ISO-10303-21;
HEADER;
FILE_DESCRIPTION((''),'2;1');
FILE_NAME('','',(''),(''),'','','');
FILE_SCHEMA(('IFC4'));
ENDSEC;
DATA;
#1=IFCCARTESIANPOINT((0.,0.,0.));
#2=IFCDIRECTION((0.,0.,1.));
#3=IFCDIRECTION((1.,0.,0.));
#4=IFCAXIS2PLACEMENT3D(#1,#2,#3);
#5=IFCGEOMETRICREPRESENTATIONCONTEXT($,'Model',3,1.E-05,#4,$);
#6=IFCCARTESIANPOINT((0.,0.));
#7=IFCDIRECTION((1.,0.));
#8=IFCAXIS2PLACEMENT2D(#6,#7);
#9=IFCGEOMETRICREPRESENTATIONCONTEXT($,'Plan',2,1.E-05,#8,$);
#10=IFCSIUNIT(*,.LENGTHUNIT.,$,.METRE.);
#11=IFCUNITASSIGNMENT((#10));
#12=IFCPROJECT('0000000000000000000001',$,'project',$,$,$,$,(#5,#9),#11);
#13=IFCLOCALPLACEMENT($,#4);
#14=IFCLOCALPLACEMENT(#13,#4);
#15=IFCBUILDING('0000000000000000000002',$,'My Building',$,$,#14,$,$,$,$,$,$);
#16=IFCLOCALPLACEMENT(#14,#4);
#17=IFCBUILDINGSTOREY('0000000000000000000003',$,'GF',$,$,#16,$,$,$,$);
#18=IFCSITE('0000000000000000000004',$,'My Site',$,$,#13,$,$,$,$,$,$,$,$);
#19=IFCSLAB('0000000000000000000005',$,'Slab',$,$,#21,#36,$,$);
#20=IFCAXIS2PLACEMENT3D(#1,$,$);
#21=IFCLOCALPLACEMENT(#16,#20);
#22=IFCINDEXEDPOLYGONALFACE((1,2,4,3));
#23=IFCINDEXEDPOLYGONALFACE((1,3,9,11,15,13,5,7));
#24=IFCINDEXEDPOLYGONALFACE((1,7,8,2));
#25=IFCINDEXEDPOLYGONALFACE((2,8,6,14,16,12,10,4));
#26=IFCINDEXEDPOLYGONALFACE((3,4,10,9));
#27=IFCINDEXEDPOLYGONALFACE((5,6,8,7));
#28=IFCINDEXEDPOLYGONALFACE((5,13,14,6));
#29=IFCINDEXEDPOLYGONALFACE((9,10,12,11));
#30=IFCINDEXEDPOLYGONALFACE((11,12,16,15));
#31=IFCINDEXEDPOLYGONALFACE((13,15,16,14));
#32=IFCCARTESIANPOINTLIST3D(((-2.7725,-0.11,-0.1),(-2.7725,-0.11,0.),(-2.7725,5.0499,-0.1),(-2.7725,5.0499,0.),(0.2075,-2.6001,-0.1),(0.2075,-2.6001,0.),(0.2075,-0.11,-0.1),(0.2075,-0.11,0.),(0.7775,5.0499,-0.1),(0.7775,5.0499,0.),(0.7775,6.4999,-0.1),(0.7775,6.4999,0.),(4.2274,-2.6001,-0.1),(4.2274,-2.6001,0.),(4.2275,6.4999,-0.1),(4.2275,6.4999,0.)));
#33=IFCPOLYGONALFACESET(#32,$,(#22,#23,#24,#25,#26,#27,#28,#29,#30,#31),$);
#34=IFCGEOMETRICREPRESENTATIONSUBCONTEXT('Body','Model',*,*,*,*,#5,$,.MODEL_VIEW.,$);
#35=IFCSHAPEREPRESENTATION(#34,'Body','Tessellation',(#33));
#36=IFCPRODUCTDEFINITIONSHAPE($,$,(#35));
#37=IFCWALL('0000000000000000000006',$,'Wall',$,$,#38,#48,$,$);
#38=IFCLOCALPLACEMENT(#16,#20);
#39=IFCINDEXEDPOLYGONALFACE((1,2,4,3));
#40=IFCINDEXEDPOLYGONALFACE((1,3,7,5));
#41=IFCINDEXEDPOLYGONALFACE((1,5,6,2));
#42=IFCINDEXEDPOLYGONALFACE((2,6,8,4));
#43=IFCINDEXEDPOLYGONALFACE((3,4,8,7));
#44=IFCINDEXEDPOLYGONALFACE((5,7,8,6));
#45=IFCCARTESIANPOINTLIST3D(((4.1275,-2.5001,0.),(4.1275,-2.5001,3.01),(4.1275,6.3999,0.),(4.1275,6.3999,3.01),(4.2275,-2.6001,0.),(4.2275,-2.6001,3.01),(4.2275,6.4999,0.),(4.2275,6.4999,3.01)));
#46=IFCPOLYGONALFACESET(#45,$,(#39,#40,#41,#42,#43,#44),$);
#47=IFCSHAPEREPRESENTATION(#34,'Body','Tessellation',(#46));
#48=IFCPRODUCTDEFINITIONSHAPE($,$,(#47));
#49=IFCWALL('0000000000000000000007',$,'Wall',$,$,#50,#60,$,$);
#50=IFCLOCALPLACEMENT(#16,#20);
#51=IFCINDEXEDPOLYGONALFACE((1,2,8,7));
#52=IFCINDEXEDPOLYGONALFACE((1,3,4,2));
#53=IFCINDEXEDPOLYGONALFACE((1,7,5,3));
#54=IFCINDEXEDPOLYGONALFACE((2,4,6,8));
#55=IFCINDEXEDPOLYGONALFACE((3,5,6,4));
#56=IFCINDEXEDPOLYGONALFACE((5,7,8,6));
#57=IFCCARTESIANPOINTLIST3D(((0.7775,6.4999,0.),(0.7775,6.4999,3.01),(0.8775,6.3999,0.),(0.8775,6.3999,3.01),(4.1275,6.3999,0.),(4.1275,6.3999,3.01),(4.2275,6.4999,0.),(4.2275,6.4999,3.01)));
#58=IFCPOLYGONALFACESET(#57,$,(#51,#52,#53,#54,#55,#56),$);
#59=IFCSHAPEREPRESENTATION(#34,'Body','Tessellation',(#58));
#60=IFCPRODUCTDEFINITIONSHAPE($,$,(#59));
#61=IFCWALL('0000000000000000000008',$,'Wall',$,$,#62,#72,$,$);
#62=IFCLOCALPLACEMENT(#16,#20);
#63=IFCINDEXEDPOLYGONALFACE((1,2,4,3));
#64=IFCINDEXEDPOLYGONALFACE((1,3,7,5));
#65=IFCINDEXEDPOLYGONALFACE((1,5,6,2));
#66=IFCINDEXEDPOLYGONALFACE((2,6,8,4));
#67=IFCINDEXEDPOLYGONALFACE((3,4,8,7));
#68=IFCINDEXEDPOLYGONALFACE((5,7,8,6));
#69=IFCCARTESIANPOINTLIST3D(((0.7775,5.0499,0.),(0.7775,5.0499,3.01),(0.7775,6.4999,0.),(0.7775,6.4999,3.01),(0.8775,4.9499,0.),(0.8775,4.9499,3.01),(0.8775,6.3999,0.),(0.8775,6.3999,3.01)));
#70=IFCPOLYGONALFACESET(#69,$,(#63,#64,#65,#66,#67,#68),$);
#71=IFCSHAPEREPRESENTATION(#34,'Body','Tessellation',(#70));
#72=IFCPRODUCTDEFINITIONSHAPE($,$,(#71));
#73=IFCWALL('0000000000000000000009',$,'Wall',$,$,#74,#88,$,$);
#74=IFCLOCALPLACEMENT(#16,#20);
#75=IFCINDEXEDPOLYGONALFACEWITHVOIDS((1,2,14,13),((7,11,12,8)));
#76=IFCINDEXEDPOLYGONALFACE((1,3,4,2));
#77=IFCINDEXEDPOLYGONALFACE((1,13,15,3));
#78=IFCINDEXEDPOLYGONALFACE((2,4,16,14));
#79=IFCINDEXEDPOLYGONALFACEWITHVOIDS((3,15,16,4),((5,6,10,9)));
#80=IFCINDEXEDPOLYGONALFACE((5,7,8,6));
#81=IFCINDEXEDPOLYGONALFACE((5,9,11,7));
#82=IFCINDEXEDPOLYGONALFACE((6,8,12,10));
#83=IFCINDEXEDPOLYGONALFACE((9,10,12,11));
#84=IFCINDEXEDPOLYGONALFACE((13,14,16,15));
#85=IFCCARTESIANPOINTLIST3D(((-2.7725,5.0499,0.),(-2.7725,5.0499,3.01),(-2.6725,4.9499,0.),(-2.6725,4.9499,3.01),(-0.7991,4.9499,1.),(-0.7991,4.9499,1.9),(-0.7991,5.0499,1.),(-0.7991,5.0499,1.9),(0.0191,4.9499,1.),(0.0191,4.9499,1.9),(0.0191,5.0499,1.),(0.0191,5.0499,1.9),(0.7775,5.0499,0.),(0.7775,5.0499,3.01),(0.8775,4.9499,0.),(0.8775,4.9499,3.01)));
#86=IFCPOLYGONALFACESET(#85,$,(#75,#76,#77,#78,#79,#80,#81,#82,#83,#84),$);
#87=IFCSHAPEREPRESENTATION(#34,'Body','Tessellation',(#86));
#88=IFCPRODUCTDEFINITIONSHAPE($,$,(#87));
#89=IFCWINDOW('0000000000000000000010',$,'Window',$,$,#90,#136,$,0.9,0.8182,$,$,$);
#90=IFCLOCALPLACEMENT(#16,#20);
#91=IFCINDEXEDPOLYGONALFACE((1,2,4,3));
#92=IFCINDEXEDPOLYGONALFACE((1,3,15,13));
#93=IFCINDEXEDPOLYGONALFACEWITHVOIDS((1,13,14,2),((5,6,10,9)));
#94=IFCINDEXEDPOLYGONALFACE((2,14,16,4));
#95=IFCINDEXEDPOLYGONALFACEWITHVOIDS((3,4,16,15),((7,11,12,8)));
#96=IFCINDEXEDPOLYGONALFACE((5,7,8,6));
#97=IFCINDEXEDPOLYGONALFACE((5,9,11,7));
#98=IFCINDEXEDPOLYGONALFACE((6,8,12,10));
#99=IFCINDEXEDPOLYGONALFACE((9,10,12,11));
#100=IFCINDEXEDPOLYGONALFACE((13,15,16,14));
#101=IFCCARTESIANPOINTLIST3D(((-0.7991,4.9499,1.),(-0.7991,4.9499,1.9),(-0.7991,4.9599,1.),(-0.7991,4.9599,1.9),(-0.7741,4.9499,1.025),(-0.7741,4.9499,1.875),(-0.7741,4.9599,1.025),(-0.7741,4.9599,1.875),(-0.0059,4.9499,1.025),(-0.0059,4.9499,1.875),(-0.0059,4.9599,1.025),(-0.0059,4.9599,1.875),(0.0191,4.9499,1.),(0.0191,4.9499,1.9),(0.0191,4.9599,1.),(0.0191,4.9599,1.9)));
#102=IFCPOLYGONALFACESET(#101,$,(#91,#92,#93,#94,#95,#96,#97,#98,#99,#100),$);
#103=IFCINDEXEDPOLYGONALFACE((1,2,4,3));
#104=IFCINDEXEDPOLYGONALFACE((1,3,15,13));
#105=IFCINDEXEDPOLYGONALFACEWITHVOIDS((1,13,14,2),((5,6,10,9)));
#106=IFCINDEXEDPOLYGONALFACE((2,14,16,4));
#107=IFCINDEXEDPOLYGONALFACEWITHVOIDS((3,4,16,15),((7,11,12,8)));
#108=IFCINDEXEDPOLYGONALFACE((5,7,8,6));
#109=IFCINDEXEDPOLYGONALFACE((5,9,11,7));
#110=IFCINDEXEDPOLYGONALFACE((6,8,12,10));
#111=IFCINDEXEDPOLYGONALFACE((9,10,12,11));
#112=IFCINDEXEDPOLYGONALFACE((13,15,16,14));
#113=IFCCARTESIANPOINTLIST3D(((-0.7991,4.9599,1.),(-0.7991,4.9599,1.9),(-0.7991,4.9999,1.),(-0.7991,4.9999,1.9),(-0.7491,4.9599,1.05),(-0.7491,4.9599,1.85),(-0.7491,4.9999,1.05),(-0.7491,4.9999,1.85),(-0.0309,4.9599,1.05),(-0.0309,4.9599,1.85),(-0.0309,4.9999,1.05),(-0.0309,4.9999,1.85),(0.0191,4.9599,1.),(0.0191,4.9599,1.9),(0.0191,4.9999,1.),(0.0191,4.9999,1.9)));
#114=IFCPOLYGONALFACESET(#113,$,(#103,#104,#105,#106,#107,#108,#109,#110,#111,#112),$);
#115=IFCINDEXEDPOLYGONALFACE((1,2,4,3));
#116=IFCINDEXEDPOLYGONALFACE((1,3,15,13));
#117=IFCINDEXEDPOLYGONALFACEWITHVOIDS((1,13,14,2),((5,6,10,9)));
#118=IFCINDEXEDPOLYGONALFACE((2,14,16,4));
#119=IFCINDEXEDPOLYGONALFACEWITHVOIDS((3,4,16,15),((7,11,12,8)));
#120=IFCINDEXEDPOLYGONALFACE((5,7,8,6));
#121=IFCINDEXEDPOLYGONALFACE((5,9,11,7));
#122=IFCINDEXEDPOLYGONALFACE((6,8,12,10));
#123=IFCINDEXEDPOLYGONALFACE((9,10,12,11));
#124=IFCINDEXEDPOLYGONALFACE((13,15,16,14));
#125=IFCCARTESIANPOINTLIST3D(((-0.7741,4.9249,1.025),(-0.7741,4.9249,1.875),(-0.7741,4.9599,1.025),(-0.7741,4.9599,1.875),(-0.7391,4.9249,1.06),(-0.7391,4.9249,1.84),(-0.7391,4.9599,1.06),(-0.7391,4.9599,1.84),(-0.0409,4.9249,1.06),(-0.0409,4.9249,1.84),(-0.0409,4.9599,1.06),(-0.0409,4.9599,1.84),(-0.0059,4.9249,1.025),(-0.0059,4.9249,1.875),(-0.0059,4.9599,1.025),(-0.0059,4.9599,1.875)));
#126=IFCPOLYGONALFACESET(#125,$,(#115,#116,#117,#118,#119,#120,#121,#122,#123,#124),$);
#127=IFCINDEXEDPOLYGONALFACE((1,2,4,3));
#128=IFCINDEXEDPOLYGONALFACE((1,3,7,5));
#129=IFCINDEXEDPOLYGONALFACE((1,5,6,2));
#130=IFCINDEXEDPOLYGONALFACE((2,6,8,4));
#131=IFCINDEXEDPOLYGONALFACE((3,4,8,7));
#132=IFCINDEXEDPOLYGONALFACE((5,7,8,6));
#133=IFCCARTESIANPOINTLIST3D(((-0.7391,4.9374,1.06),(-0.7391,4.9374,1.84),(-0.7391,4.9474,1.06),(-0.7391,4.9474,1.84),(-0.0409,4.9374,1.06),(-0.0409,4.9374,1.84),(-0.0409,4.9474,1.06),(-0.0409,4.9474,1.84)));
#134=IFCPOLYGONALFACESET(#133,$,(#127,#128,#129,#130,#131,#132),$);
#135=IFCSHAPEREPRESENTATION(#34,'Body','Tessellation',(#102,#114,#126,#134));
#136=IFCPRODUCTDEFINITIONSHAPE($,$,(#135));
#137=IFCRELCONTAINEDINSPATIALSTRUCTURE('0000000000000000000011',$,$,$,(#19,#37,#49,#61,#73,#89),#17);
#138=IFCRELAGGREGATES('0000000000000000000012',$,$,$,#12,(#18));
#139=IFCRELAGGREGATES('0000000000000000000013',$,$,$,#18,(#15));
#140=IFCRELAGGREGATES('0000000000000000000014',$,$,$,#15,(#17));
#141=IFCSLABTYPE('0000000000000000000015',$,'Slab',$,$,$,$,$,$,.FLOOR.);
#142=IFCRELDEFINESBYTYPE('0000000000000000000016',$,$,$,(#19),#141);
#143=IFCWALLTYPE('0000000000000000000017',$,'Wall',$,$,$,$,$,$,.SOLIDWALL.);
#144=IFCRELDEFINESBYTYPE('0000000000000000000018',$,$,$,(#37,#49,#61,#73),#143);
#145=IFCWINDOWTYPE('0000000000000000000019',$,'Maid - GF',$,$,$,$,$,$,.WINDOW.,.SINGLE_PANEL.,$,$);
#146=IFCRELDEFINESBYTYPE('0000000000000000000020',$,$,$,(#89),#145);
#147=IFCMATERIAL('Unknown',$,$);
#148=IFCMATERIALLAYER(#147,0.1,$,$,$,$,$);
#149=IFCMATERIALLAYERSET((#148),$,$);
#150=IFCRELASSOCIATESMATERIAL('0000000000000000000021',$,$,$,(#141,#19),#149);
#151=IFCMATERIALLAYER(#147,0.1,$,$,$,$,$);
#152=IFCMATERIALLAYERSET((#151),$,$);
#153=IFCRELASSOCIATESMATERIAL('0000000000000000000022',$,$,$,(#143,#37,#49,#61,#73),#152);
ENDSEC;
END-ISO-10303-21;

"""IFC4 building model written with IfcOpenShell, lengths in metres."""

from ifc_helpers import new_model, entity, si_unit, frame, origin_with_axes, origin_2d_with_axis, place, context, subcontext, project, spatial, line, indexed_curve, outline, extrude, shape, source, transform, mapped, material, layer, layer_set, layer_usage, type_object, type_shapes, element, fill, save


model = new_model("IFC4")

# Units and contexts
model_context = context("Model", 3, precision=1e-05, world=origin_with_axes())
plan_context = context("Plan", 2, precision=1e-05, world=origin_2d_with_axis())
body_context_1 = subcontext(model_context, "Body", "Model", "MODEL_VIEW")
body_context_2 = subcontext(plan_context, "Body", "Plan", "PLAN_VIEW")
ifc_project = project(units=[si_unit("LENGTHUNIT", "METRE")], contexts=[model_context, plan_context])

# Site, building, storey
site_placement = place(None, origin_with_axes())
site = spatial("IfcSite", under=ifc_project, at=site_placement, Name="My Site")
building_placement = place(site_placement, origin_with_axes())
building = spatial("IfcBuilding", under=site, at=building_placement, Name="My Building")
storey_placement = place(building_placement, origin_with_axes())
storey = spatial("IfcBuildingStorey", under=building, at=storey_placement, Name="GF")

# Slab
ifc_material = material(Name="Unknown")
ifc_layer_1 = layer(ifc_material, 0.1)
ifc_layer_set_1 = layer_set([ifc_layer_1])
ifc_layer_usage_1 = layer_usage(ifc_layer_set_1, "AXIS3", "POSITIVE", -0.1)
slab_type = type_object("IfcSlabType", Name="Slab", PredefinedType="FLOOR", material=ifc_layer_set_1)
slab_placement = place(storey_placement, frame((4.2275, 6.4999, 0.0), z_axis=(0.0, 0.0, 1.0), x_axis=(1.0, 0.0, 0.0)))
element("IfcSlab", 1, at=slab_placement, inside=storey, type_object=slab_type, material=ifc_layer_usage_1, Name="Slab", context=body_context_1, shape_type="SweptSolid", body=[
    extrude(outline(indexed_curve([(0.0, 0.0), (-3.45, 0.0), (-3.45, -1.45), (-7.0, -1.45), (-7.0, -6.61), (-4.02, -6.61), (-4.02, -9.1), (-0.0001, -9.1), (0.0, 0.0)])), frame((0.0, 0.0, -0.1), z_axis=(0.0, 0.0, 1.0), x_axis=(1.0, 0.0, 0.0)), (0.0, 0.0, 1.0), 0.1),
])

# Shared definitions
ifc_layer_2 = layer(ifc_material, 0.1)
ifc_layer_set_2 = layer_set([ifc_layer_2])
wall_type = type_object("IfcWallType", Name="Wall", PredefinedType="SOLIDWALL", material=ifc_layer_set_2)

# Walls
ifc_layer_usage_2 = layer_usage(ifc_layer_set_2, "AXIS2", "POSITIVE", 0.0)
wall_1_placement = place(storey_placement, frame((4.2275, -2.6001, 0.0), z_axis=(0.0, 0.0, 1.0), x_axis=(0.0, 1.0, 0.0)))
element("IfcWall", 2, at=wall_1_placement, inside=storey, type_object=wall_type, material=ifc_layer_usage_2, Name="Wall", context=body_context_1, shape_type="SweptSolid", body=[
    extrude(outline(indexed_curve([(0.0, 0.0), (0.1, 0.1), (9.0, 0.1), (9.1, 0.0)], segments=[line(1, 2, 3, 4, 1)])), origin_with_axes(), (0.0, 0.0, 1.0), 3.01),
])
ifc_layer_usage_3 = layer_usage(ifc_layer_set_2, "AXIS2", "POSITIVE", 0.0)
wall_2_placement = place(storey_placement, frame((4.2275, 6.4999, 0.0), z_axis=(0.0, 0.0, 1.0), x_axis=(-1.0, 0.0, 0.0)))
element("IfcWall", 3, at=wall_2_placement, inside=storey, type_object=wall_type, material=ifc_layer_usage_3, Name="Wall", context=body_context_1, shape_type="SweptSolid", body=[
    extrude(outline(indexed_curve([(0.0, 0.0), (0.1, 0.1), (3.35, 0.1), (3.45, 0.0)], segments=[line(1, 2, 3, 4, 1)])), origin_with_axes(), (0.0, 0.0, 1.0), 3.01),
])
ifc_layer_usage_4 = layer_usage(ifc_layer_set_2, "AXIS2", "POSITIVE", 0.0)
wall_3_placement = place(storey_placement, frame((0.7775, 6.4999, 0.0), z_axis=(0.0, 0.0, 1.0), x_axis=(0.0, -1.0, 0.0)))
element("IfcWall", 4, at=wall_3_placement, inside=storey, type_object=wall_type, material=ifc_layer_usage_4, Name="Wall", context=body_context_1, shape_type="SweptSolid", body=[
    extrude(outline(indexed_curve([(0.0, 0.0), (0.1, 0.1), (1.55, 0.1), (1.45, 0.0)], segments=[line(1, 2, 3, 4, 1)])), origin_with_axes(), (0.0, 0.0, 1.0), 3.01),
])

# Wall, opening, window
ifc_layer_usage_5 = layer_usage(ifc_layer_set_2, "AXIS2", "POSITIVE", 0.0)
wall_4_placement = place(storey_placement, frame((0.7775, 5.0499, 0.0), z_axis=(0.0, 0.0, 1.0), x_axis=(-1.0, 0.0, 0.0)))
wall_4 = element("IfcWall", 5, at=wall_4_placement, inside=storey, type_object=wall_type, material=ifc_layer_usage_5, Name="Wall", context=body_context_1, shape_type="SweptSolid", body=[
    extrude(outline(indexed_curve([(0.0, 0.0), (-0.1, 0.1), (3.45, 0.1), (3.55, 0.0)], segments=[line(1, 2, 3, 4, 1)])), origin_with_axes(), (0.0, 0.0, 1.0), 3.01),
])
shared_shape_1 = source(origin_with_axes(), body_context_1, "Body", "SweptSolid", [
    extrude(outline(indexed_curve([(0.0, 0.0), (0.8182, 0.0), (0.8182, 0.9), (0.0, 0.9)], segments=[line(1, 2, 3, 4, 1)])), frame((0.0, -0.6, 0.0), z_axis=(0.0, -1.0, 0.0), x_axis=(1.0, 0.0, 0.0)), (0.0, 0.0, -1.0), 1.2),
])
opening_1_placement = place(wall_4_placement, frame((0.7584, 0.0, 1.0), z_axis=(0.0, 0.0, 1.0), x_axis=(1.0, 0.0, 0.0)))
opening_1 = element("IfcOpeningElement", 6, at=opening_1_placement, cuts=wall_4, PredefinedType="OPENING", context=body_context_1, shape_type="MappedRepresentation", body=[
    mapped(shared_shape_1, transform((0.0, 0.0, 0.0), x_axis=(1.0, 0.0, 0.0), y_axis=(0.0, 1.0, 0.0), z_axis=(0.0, 0.0, 1.0), scale=1.0)),
])
window_type_1 = type_object("IfcWindowType", Name="Maid - GF", PartitioningType="SINGLE_PANEL", PredefinedType="WINDOW")
shared_shape_2 = source(origin_with_axes(), body_context_1, "Body", "SweptSolid", [
    extrude(outline(indexed_curve([(0.0, 0.0), (0.8182, 0.0), (0.8182, 0.9), (0.0, 0.9)], segments=[line(1, 2, 3, 4, 1)]), holes=[indexed_curve([(0.025, 0.025), (0.7932, 0.025), (0.7932, 0.875), (0.025, 0.875)], segments=[line(1, 2, 3, 4, 1)])]), frame((0.0, 0.09, 0.0), z_axis=(0.0, -1.0, 0.0), x_axis=(1.0, 0.0, 0.0)), (0.0, 0.0, -1.0), 0.01),
    extrude(outline(indexed_curve([(0.0, 0.0), (0.8182, 0.0), (0.8182, 0.9), (0.0, 0.9)], segments=[line(1, 2, 3, 4, 1)]), holes=[indexed_curve([(0.05, 0.05), (0.7682, 0.05), (0.7682, 0.85), (0.05, 0.85)], segments=[line(1, 2, 3, 4, 1)])]), frame((0.0, 0.05, 0.0), z_axis=(0.0, -1.0, 0.0), x_axis=(1.0, 0.0, 0.0)), (0.0, 0.0, -1.0), 0.04),
    extrude(outline(indexed_curve([(0.0, 0.0), (0.7682, 0.0), (0.7682, 0.85), (0.0, 0.85)], segments=[line(1, 2, 3, 4, 1)]), holes=[indexed_curve([(0.035, 0.035), (0.7332, 0.035), (0.7332, 0.815), (0.035, 0.815)], segments=[line(1, 2, 3, 4, 1)])]), frame((0.025, 0.09, 0.025), z_axis=(0.0, -1.0, 0.0), x_axis=(1.0, 0.0, 0.0)), (0.0, 0.0, -1.0), 0.035),
    extrude(outline(indexed_curve([(0.035, 0.035), (0.7332, 0.035), (0.7332, 0.815), (0.035, 0.815)], segments=[line(1, 2, 3, 4, 1)])), frame((0.025, 0.1025, 0.025), z_axis=(0.0, -1.0, 0.0), x_axis=(1.0, 0.0, 0.0)), (0.0, 0.0, -1.0), 0.01),
])
shared_shape_3 = source(origin_with_axes(), body_context_2, "Body", "Curve2D", [
    entity("IfcIndexedPolyCurve", entity("IfcCartesianPointList2D", [[0.05, 0.05], [0.7682, 0.05]])),
    entity("IfcIndexedPolyCurve", entity("IfcCartesianPointList2D", [[0.0, 0.1], [0.025, 0.1], [0.025, 0.09], [0.05, 0.09], [0.05, 0.05], [0.0, 0.05]]), [entity("IfcLineIndex", [1, 2, 3, 4, 5, 6, 1])]),
    entity("IfcIndexedPolyCurve", entity("IfcCartesianPointList2D", [[0.8182, 0.1], [0.7932, 0.1], [0.7932, 0.09], [0.7682, 0.09], [0.7682, 0.05], [0.8182, 0.05]]), [entity("IfcLineIndex", [1, 2, 3, 4, 5, 6, 1])]),
    entity("IfcIndexedPolyCurve", entity("IfcCartesianPointList2D", [[0.025, 0.09], [0.06, 0.09], [0.06, 0.125], [0.025, 0.125]]), [entity("IfcLineIndex", [1, 2, 3, 4, 1])]),
    entity("IfcIndexedPolyCurve", entity("IfcCartesianPointList2D", [[0.7932, 0.09], [0.7582, 0.09], [0.7582, 0.125], [0.7932, 0.125]]), [entity("IfcLineIndex", [1, 2, 3, 4, 1])]),
    entity("IfcIndexedPolyCurve", entity("IfcCartesianPointList2D", [[0.06, 0.09], [0.7582, 0.09]])),
    entity("IfcIndexedPolyCurve", entity("IfcCartesianPointList2D", [[0.06, 0.125], [0.7582, 0.125]])),
    entity("IfcIndexedPolyCurve", entity("IfcCartesianPointList2D", [[0.06, 0.1075], [0.7582, 0.1075]])),
])
type_shapes(window_type_1, [shared_shape_2, shared_shape_3])
window_1_placement = place(opening_1_placement, frame((0.0, 0.0, 0.0), z_axis=(0.0, 0.0, 1.0), x_axis=(1.0, 0.0, 0.0)))
window_1 = element("IfcWindow", 7, at=window_1_placement, inside=storey, type_object=window_type_1, Name="Window", OverallHeight=0.9, OverallWidth=0.8182, shapes=[
    shape(body_context_1, "Body", "MappedRepresentation", [mapped(shared_shape_2, transform((0.0, 0.0, 0.0), x_axis=(1.0, 0.0, 0.0), y_axis=(0.0, 1.0, 0.0), z_axis=(0.0, 0.0, 1.0), scale=1.0))]),
    shape(body_context_2, "Body", "MappedRepresentation", [mapped(shared_shape_3, transform((0.0, 0.0, 0.0), x_axis=(1.0, 0.0, 0.0), y_axis=(0.0, 1.0, 0.0), z_axis=(0.0, 0.0, 1.0), scale=1.0))]),
])
fill(opening_1, window_1)

save(model, "model.ifc")
